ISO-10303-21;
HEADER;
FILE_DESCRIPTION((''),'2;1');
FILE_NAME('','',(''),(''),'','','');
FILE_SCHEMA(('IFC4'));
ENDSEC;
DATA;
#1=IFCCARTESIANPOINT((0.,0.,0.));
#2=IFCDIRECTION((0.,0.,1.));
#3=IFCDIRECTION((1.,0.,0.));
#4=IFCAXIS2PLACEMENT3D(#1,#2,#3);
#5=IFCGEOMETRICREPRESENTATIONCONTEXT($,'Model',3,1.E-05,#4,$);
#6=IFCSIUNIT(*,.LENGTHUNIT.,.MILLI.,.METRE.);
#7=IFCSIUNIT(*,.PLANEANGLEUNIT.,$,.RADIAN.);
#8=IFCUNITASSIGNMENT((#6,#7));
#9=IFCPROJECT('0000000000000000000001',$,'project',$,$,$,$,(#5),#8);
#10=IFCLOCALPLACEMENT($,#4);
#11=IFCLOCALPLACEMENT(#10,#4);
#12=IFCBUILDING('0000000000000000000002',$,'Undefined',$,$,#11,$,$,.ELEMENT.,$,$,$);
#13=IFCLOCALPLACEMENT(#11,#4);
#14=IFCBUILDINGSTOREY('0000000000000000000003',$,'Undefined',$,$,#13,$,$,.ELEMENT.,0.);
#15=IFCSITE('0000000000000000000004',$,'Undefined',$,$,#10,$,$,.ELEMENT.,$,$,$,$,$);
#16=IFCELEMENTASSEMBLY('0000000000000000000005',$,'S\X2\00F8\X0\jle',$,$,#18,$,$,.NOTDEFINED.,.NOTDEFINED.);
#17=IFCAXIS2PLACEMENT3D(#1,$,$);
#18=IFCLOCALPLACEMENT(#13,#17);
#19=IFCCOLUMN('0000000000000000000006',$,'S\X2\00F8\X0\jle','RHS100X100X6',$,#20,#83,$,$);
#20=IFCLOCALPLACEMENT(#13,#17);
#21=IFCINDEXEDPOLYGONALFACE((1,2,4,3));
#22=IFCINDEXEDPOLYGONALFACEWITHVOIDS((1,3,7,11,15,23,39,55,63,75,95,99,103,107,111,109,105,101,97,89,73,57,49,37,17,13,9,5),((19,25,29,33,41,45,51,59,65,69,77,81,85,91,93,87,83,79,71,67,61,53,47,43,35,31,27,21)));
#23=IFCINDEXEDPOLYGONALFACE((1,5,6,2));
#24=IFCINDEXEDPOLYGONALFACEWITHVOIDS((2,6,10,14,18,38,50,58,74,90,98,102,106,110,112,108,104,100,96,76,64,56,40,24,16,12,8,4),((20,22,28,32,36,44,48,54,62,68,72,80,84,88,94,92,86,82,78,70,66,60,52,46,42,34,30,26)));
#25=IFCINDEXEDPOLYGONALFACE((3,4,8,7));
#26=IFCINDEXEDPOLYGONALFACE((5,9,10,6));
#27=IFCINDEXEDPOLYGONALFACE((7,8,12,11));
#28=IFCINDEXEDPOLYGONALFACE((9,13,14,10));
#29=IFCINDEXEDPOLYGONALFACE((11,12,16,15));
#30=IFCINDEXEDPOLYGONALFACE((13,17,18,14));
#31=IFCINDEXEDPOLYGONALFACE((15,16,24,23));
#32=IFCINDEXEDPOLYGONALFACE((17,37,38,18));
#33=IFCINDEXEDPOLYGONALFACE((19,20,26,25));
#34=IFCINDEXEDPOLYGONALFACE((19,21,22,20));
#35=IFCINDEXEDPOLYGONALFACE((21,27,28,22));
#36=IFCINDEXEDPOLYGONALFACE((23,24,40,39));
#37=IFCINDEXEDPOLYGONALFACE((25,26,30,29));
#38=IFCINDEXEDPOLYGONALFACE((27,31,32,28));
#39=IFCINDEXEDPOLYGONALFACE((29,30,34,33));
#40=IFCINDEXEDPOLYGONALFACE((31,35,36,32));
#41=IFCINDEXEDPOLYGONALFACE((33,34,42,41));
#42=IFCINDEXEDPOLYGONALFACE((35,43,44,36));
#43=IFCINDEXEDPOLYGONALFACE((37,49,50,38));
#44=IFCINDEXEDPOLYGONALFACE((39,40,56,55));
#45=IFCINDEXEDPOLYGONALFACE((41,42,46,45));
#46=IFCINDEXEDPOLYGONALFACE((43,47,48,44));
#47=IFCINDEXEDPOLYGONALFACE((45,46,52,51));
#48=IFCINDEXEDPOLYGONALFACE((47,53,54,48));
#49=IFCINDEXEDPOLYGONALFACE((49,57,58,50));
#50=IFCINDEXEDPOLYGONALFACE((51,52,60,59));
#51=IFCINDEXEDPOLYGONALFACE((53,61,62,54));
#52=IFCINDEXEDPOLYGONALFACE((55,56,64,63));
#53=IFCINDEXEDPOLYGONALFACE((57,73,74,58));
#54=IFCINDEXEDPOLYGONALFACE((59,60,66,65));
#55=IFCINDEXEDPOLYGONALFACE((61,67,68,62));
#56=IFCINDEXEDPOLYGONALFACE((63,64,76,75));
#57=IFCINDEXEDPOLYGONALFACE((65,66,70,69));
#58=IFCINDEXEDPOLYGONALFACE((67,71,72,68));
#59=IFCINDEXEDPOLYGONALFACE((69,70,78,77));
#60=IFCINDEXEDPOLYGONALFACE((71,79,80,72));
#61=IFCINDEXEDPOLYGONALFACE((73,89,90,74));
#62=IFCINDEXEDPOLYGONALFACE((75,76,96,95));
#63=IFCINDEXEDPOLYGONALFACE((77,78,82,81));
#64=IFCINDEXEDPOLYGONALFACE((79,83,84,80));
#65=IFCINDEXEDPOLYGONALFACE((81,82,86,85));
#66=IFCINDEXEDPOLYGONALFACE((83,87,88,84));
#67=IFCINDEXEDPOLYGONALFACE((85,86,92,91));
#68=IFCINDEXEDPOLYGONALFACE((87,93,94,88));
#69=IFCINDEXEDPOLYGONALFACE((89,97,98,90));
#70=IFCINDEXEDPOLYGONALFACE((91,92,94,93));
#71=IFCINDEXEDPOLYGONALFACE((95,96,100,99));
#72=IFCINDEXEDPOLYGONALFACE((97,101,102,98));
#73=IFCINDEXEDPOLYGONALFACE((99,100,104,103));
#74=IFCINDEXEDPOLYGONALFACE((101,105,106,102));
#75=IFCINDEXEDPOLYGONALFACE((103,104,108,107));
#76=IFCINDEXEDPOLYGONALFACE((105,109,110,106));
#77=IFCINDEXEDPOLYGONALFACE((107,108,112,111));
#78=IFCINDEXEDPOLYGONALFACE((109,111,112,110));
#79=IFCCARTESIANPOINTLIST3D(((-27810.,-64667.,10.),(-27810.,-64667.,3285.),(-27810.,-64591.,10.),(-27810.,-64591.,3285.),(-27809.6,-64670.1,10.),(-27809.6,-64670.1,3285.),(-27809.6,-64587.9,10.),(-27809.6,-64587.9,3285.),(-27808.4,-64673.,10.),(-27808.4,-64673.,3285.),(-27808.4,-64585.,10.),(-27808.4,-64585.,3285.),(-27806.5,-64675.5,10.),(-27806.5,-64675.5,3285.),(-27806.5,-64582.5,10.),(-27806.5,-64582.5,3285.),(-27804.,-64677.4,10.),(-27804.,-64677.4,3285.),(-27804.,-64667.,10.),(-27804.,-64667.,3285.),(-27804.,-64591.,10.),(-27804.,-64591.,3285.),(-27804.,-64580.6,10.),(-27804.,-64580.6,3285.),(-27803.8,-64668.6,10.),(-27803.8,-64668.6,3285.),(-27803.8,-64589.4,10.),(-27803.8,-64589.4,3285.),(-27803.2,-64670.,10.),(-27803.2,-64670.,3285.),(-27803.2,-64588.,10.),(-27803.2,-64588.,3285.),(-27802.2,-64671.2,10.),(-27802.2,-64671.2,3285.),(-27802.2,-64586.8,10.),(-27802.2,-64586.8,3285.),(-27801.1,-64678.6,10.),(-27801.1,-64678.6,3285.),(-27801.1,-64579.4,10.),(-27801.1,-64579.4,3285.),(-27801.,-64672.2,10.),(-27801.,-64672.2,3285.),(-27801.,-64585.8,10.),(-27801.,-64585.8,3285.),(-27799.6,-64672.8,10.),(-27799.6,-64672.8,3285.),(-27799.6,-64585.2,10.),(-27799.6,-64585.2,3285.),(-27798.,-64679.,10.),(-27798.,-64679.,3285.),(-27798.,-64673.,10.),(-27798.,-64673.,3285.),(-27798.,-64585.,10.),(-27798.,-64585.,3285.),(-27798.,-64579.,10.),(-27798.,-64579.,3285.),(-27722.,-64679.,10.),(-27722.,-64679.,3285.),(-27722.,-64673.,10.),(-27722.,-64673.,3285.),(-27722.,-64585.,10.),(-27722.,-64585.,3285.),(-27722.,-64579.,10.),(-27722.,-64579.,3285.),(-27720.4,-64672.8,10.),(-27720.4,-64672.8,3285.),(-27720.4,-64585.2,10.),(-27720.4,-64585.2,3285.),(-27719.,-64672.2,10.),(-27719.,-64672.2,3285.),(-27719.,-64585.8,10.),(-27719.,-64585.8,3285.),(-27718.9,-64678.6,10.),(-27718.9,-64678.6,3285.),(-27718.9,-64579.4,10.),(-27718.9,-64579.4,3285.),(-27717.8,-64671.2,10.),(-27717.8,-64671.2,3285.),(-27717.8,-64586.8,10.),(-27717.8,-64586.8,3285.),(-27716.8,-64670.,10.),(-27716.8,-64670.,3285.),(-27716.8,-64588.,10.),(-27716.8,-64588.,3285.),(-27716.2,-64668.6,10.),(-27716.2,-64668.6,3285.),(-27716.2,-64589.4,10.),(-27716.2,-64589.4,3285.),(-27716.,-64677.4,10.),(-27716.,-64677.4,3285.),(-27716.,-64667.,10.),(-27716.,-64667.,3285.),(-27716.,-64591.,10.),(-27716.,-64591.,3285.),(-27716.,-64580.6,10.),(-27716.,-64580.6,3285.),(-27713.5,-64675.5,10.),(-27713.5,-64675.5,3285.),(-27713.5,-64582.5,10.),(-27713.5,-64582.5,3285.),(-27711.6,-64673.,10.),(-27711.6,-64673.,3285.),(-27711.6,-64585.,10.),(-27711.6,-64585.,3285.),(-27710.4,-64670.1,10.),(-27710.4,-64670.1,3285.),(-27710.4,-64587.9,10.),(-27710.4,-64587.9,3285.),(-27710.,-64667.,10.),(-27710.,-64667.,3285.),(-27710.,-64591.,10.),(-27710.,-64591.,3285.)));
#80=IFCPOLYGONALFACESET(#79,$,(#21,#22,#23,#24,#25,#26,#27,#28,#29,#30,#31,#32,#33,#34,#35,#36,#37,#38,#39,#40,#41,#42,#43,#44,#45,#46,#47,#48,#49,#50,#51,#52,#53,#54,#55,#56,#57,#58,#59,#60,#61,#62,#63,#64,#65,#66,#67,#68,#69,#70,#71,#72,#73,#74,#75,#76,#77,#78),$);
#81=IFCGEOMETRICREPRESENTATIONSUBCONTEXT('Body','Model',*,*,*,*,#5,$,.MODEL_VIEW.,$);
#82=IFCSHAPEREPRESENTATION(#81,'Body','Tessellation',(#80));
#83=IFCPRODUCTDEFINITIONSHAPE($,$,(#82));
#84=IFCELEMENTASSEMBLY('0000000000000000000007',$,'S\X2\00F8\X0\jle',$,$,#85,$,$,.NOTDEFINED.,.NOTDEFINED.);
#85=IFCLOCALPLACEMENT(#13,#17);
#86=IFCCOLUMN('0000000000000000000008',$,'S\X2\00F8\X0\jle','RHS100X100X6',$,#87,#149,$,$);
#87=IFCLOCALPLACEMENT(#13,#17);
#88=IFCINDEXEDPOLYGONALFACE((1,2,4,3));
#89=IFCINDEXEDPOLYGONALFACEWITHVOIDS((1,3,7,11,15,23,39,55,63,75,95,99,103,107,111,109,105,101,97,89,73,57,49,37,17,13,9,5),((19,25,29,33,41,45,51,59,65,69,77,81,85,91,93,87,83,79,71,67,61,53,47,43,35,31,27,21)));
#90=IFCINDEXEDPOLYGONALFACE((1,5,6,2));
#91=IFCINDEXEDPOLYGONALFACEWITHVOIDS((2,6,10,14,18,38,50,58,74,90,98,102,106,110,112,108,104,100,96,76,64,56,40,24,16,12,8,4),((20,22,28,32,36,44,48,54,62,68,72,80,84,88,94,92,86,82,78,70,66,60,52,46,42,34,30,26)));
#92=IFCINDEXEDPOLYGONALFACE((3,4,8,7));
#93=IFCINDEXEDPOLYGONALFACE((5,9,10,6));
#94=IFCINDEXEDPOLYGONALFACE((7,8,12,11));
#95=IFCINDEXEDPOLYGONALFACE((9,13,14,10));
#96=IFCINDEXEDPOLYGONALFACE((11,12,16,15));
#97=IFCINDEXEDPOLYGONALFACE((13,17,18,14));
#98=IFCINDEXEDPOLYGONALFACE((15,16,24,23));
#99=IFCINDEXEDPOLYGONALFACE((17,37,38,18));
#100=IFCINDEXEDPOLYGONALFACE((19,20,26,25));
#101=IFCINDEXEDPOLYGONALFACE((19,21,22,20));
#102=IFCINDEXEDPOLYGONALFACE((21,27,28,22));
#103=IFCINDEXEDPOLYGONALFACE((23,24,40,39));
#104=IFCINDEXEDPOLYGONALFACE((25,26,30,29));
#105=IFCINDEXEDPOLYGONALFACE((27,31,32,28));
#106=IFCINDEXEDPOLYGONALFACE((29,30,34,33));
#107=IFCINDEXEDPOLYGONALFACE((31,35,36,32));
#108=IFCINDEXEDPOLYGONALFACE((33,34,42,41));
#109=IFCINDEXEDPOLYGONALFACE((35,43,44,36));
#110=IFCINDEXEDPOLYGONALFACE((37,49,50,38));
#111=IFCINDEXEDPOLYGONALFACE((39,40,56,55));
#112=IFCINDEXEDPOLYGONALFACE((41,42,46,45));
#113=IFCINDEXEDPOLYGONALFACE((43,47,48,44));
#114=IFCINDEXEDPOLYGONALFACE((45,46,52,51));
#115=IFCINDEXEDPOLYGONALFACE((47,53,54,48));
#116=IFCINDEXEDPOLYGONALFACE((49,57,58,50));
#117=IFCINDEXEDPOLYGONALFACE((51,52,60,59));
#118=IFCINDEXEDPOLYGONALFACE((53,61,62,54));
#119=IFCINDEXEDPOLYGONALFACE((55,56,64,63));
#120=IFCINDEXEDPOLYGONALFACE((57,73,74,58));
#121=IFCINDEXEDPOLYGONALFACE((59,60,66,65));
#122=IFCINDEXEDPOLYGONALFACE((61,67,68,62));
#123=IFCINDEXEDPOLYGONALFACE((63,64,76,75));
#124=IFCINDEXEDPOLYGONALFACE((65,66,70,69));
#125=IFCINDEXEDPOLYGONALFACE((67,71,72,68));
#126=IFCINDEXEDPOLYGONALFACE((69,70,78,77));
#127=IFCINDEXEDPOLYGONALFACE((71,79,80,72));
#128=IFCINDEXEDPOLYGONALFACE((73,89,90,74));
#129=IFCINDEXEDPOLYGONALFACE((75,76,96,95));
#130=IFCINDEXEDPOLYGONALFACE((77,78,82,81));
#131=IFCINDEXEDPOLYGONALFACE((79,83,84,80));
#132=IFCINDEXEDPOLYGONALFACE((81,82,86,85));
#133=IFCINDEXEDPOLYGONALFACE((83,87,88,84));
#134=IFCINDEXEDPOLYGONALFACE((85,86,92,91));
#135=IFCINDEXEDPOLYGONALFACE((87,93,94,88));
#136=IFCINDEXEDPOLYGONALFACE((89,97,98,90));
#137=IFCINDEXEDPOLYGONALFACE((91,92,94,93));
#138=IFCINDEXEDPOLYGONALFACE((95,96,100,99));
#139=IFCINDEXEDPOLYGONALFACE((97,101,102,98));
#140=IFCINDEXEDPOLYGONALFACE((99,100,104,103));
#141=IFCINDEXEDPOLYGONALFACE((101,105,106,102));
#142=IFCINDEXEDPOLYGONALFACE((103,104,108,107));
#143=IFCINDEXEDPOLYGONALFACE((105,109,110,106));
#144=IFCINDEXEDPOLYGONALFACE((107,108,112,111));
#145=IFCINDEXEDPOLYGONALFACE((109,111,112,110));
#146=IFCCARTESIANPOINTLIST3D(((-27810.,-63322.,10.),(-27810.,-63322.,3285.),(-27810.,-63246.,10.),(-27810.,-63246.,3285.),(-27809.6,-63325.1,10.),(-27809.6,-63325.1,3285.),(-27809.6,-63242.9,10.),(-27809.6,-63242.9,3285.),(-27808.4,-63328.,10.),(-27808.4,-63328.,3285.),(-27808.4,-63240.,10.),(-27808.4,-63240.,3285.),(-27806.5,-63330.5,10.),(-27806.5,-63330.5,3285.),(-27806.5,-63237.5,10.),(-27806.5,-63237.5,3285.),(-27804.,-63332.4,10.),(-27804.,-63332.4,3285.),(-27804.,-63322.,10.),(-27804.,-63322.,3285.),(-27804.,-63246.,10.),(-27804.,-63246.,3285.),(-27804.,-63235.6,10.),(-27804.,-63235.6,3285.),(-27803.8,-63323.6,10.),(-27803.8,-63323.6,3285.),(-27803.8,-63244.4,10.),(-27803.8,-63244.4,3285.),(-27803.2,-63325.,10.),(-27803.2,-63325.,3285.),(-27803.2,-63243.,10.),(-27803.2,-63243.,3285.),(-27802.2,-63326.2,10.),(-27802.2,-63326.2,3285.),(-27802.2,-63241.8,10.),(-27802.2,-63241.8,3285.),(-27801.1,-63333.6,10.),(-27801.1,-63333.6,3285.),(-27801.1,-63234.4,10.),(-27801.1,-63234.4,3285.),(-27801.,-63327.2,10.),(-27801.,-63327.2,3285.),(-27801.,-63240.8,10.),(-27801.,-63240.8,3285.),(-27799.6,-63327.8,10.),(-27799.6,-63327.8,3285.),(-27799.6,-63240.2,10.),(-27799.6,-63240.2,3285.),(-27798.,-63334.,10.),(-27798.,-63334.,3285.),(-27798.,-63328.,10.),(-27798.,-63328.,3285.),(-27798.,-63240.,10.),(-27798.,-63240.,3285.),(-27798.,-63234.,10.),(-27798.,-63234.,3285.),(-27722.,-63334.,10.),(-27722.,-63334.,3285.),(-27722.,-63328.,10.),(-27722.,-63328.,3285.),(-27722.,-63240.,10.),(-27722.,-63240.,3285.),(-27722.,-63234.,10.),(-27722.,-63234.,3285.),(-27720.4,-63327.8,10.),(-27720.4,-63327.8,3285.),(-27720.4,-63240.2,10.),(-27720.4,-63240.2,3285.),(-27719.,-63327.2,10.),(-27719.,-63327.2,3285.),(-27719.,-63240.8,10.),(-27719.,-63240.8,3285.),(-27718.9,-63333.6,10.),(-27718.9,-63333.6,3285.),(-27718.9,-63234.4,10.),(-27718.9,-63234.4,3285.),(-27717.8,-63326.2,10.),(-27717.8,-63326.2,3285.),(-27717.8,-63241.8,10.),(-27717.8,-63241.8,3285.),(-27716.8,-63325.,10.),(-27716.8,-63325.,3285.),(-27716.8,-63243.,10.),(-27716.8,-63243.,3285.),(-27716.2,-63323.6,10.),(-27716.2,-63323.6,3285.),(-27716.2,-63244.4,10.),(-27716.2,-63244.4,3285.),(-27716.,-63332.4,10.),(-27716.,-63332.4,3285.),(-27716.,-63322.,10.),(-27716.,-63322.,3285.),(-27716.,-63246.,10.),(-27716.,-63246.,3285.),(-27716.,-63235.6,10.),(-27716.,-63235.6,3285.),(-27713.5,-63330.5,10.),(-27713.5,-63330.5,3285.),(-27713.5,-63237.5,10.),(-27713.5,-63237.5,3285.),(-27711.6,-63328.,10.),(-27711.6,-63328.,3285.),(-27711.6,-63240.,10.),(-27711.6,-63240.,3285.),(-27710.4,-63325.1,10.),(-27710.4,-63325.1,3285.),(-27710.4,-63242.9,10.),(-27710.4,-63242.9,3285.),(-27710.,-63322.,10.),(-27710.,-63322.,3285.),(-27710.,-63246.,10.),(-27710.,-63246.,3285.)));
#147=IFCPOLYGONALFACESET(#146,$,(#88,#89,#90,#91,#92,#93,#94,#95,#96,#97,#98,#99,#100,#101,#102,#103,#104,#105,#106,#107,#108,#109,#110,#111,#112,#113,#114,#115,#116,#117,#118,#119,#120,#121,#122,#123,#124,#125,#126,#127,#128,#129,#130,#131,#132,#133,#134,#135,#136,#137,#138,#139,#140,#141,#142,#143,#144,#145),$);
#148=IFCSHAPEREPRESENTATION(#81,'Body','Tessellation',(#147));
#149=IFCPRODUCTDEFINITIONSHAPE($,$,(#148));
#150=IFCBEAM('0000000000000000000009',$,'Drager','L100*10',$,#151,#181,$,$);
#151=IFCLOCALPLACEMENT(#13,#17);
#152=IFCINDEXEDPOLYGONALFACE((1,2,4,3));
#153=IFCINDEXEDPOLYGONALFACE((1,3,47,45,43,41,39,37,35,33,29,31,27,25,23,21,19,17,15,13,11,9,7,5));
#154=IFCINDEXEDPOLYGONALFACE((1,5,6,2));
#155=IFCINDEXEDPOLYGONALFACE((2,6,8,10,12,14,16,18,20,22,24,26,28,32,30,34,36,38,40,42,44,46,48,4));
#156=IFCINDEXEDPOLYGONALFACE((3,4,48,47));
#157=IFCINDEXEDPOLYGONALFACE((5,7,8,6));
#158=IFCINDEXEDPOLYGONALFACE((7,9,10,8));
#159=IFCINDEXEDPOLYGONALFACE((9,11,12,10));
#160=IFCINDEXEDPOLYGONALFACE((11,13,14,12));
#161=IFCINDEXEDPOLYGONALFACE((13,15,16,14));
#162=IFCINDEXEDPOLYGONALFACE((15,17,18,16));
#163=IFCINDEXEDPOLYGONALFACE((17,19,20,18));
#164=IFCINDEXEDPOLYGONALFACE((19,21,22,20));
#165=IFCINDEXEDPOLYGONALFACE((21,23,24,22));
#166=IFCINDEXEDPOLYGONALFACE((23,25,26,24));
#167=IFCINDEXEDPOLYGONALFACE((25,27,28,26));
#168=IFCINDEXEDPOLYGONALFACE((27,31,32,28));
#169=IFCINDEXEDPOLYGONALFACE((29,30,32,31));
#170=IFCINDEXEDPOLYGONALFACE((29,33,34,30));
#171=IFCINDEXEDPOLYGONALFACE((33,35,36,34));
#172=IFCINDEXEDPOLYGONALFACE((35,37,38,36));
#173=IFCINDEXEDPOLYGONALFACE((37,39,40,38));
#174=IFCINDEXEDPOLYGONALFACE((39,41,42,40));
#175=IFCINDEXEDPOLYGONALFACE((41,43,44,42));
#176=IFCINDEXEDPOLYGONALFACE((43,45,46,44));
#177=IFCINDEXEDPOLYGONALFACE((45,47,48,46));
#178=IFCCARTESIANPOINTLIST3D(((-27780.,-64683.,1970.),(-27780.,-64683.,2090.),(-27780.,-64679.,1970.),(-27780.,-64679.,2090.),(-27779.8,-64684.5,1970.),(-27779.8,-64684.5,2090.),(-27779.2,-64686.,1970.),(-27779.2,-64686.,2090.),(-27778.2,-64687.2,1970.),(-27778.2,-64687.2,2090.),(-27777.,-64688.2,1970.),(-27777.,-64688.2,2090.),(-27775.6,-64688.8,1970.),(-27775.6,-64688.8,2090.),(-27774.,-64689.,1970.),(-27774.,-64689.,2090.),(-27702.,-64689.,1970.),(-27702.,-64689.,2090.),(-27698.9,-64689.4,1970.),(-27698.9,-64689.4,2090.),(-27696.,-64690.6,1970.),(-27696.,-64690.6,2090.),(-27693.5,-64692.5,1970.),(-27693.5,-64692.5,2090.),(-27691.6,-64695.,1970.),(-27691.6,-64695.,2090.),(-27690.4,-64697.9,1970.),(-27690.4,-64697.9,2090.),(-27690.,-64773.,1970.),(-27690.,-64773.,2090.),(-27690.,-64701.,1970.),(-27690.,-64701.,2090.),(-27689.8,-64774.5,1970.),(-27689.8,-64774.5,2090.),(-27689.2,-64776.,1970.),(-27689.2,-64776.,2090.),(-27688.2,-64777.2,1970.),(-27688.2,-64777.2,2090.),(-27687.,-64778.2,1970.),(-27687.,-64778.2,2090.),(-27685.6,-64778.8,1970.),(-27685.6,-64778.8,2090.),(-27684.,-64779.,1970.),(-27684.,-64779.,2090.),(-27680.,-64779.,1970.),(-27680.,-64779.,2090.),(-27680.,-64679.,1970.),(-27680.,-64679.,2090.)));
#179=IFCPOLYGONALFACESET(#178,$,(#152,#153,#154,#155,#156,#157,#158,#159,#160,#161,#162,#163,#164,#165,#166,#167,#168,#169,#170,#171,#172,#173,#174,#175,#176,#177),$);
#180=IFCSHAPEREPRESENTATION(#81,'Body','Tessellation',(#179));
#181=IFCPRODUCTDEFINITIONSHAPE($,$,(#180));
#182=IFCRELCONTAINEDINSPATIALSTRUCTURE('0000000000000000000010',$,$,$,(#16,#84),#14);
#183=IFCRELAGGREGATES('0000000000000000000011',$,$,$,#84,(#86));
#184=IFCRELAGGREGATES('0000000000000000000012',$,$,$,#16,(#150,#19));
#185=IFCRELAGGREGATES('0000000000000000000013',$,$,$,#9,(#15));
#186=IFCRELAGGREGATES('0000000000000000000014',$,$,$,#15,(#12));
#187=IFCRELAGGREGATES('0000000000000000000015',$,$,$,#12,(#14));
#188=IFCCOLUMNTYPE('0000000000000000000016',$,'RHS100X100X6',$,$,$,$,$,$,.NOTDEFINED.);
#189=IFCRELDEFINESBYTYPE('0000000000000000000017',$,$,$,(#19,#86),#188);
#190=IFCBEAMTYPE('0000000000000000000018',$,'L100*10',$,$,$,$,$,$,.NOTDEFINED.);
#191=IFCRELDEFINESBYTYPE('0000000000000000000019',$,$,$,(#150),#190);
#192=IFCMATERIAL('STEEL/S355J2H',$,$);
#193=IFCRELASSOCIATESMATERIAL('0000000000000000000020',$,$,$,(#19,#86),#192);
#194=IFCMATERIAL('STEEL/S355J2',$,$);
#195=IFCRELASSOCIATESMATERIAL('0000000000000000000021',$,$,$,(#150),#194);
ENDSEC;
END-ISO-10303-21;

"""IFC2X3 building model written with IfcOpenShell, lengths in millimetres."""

from ifc_helpers import new_model, si_unit, frame, origin_with_axes, origin_2d_with_axis, place, context, subcontext, project, spatial, hollow_rectangle, l_section, extrude, clip, halfspace, material, type_object, element, aggregate, save


model = new_model("IFC2X3")

# Units and contexts
model_context = context("Model", 3, precision=1e-05, world=origin_with_axes())
body_context = subcontext(model_context, "Body", "Model", "MODEL_VIEW")
ifc_project = project(units=[si_unit("LENGTHUNIT", "METRE", prefix="MILLI"), si_unit("PLANEANGLEUNIT", "RADIAN")], contexts=[model_context])

# Site, building, storey
site_placement = place(None, origin_with_axes())
site = spatial("IfcSite", under=ifc_project, at=site_placement, Name="Undefined", CompositionType="ELEMENT")
building_placement = place(site_placement, origin_with_axes())
building = spatial("IfcBuilding", under=site, at=building_placement, Name="Undefined", CompositionType="ELEMENT")
storey_placement = place(building_placement, origin_with_axes())
storey = spatial("IfcBuildingStorey", under=building, at=storey_placement, Name="Undefined", CompositionType="ELEMENT", Elevation=0.0)

# Element assemblies, columns
assembly_1_placement = place(storey_placement, origin_with_axes())
assembly_1 = element("IfcElementAssembly", 1, at=assembly_1_placement, inside=storey, Name="Søjle", AssemblyPlace="NOTDEFINED", PredefinedType="NOTDEFINED")
ifc_material_1 = material(Name="STEEL/S355J2H")
column_type = type_object("IfcColumnType", Name="RHS100X100X6", PredefinedType="NOTDEFINED")
column_1_placement = place(assembly_1_placement, frame((-27760.0, -64629.0, 0.0), z_axis=(0.0, 0.0, 1.0), x_axis=(0.0, 1.0, 0.0)))
column_1 = element("IfcColumn", 2, at=column_1_placement, type_object=column_type, material=ifc_material_1, Name="Søjle", Description="RHS100X100X6", context=body_context, shape_type="Clipping", body=[
    clip(clip(extrude(hollow_rectangle(XDim=100.0, YDim=100.0, WallThickness=6.0, InnerFilletRadius=6.0, OuterFilletRadius=12.0, at=origin_2d_with_axis()), frame((0.0, 0.0, 3295.0), z_axis=(0.0, 0.0, -1.0), x_axis=(0.0, 1.0, 0.0)), (0.0, 0.0, 1.0), 3295.0), halfspace(frame((-50.0, 0.0, 3285.0), z_axis=(0.0, 0.0, -1.0), x_axis=(0.0, -1.0, 0.0)), True)), halfspace(frame((0.0, -50.0, 10.0), z_axis=(0.0, 0.0, 1.0), x_axis=(-1.0, 0.0, 0.0)), True)),
])
assembly_2_placement = place(storey_placement, origin_with_axes())
assembly_2 = element("IfcElementAssembly", 3, at=assembly_2_placement, inside=storey, Name="Søjle", AssemblyPlace="NOTDEFINED", PredefinedType="NOTDEFINED")
column_2_placement = place(assembly_2_placement, frame((-27760.0, -63284.0, 0.0), z_axis=(0.0, 0.0, 1.0), x_axis=(0.0, 1.0, 0.0)))
column_2 = element("IfcColumn", 4, at=column_2_placement, type_object=column_type, material=ifc_material_1, Name="Søjle", Description="RHS100X100X6", context=body_context, shape_type="Clipping", body=[
    clip(clip(extrude(hollow_rectangle(XDim=100.0, YDim=100.0, WallThickness=6.0, InnerFilletRadius=6.0, OuterFilletRadius=12.0, at=origin_2d_with_axis()), frame((0.0, 0.0, 3295.0), z_axis=(0.0, 0.0, -1.0), x_axis=(0.0, 1.0, 0.0)), (0.0, 0.0, 1.0), 3295.0), halfspace(frame((-50.0, 0.0, 3285.0), z_axis=(0.0, 0.0, -1.0), x_axis=(0.0, -1.0, 0.0)), True)), halfspace(frame((0.0, -50.0, 10.0), z_axis=(0.0, 0.0, 1.0), x_axis=(-1.0, 0.0, 0.0)), True)),
])

# Beam
ifc_material_2 = material(Name="STEEL/S355J2")
beam_type_1 = type_object("IfcBeamType", Name="L100*10", PredefinedType="NOTDEFINED")
beam_1_placement = place(assembly_1_placement, frame((-27730.0, -64729.0, 2090.0), z_axis=(0.0, -1.0, 0.0), x_axis=(0.0, 0.0, -1.0)))
beam_1 = element("IfcBeam", 5, at=beam_1_placement, type_object=beam_type_1, material=ifc_material_2, Name="Drager", Description="L100*10", context=body_context, shape_type="SweptSolid", body=[
    extrude(l_section(Depth=100.0, Width=100.0, Thickness=10.0, FilletRadius=12.0, EdgeRadius=6.0, at=origin_2d_with_axis()), frame((120.0, 0.0, 0.0), z_axis=(-1.0, 0.0, 0.0), x_axis=(0.0, -1.0, 0.0)), (0.0, 0.0, 1.0), 120.0),
])

aggregate(assembly_2, [column_2])
aggregate(assembly_1, [beam_1, column_1])

save(model, "model.ifc")
